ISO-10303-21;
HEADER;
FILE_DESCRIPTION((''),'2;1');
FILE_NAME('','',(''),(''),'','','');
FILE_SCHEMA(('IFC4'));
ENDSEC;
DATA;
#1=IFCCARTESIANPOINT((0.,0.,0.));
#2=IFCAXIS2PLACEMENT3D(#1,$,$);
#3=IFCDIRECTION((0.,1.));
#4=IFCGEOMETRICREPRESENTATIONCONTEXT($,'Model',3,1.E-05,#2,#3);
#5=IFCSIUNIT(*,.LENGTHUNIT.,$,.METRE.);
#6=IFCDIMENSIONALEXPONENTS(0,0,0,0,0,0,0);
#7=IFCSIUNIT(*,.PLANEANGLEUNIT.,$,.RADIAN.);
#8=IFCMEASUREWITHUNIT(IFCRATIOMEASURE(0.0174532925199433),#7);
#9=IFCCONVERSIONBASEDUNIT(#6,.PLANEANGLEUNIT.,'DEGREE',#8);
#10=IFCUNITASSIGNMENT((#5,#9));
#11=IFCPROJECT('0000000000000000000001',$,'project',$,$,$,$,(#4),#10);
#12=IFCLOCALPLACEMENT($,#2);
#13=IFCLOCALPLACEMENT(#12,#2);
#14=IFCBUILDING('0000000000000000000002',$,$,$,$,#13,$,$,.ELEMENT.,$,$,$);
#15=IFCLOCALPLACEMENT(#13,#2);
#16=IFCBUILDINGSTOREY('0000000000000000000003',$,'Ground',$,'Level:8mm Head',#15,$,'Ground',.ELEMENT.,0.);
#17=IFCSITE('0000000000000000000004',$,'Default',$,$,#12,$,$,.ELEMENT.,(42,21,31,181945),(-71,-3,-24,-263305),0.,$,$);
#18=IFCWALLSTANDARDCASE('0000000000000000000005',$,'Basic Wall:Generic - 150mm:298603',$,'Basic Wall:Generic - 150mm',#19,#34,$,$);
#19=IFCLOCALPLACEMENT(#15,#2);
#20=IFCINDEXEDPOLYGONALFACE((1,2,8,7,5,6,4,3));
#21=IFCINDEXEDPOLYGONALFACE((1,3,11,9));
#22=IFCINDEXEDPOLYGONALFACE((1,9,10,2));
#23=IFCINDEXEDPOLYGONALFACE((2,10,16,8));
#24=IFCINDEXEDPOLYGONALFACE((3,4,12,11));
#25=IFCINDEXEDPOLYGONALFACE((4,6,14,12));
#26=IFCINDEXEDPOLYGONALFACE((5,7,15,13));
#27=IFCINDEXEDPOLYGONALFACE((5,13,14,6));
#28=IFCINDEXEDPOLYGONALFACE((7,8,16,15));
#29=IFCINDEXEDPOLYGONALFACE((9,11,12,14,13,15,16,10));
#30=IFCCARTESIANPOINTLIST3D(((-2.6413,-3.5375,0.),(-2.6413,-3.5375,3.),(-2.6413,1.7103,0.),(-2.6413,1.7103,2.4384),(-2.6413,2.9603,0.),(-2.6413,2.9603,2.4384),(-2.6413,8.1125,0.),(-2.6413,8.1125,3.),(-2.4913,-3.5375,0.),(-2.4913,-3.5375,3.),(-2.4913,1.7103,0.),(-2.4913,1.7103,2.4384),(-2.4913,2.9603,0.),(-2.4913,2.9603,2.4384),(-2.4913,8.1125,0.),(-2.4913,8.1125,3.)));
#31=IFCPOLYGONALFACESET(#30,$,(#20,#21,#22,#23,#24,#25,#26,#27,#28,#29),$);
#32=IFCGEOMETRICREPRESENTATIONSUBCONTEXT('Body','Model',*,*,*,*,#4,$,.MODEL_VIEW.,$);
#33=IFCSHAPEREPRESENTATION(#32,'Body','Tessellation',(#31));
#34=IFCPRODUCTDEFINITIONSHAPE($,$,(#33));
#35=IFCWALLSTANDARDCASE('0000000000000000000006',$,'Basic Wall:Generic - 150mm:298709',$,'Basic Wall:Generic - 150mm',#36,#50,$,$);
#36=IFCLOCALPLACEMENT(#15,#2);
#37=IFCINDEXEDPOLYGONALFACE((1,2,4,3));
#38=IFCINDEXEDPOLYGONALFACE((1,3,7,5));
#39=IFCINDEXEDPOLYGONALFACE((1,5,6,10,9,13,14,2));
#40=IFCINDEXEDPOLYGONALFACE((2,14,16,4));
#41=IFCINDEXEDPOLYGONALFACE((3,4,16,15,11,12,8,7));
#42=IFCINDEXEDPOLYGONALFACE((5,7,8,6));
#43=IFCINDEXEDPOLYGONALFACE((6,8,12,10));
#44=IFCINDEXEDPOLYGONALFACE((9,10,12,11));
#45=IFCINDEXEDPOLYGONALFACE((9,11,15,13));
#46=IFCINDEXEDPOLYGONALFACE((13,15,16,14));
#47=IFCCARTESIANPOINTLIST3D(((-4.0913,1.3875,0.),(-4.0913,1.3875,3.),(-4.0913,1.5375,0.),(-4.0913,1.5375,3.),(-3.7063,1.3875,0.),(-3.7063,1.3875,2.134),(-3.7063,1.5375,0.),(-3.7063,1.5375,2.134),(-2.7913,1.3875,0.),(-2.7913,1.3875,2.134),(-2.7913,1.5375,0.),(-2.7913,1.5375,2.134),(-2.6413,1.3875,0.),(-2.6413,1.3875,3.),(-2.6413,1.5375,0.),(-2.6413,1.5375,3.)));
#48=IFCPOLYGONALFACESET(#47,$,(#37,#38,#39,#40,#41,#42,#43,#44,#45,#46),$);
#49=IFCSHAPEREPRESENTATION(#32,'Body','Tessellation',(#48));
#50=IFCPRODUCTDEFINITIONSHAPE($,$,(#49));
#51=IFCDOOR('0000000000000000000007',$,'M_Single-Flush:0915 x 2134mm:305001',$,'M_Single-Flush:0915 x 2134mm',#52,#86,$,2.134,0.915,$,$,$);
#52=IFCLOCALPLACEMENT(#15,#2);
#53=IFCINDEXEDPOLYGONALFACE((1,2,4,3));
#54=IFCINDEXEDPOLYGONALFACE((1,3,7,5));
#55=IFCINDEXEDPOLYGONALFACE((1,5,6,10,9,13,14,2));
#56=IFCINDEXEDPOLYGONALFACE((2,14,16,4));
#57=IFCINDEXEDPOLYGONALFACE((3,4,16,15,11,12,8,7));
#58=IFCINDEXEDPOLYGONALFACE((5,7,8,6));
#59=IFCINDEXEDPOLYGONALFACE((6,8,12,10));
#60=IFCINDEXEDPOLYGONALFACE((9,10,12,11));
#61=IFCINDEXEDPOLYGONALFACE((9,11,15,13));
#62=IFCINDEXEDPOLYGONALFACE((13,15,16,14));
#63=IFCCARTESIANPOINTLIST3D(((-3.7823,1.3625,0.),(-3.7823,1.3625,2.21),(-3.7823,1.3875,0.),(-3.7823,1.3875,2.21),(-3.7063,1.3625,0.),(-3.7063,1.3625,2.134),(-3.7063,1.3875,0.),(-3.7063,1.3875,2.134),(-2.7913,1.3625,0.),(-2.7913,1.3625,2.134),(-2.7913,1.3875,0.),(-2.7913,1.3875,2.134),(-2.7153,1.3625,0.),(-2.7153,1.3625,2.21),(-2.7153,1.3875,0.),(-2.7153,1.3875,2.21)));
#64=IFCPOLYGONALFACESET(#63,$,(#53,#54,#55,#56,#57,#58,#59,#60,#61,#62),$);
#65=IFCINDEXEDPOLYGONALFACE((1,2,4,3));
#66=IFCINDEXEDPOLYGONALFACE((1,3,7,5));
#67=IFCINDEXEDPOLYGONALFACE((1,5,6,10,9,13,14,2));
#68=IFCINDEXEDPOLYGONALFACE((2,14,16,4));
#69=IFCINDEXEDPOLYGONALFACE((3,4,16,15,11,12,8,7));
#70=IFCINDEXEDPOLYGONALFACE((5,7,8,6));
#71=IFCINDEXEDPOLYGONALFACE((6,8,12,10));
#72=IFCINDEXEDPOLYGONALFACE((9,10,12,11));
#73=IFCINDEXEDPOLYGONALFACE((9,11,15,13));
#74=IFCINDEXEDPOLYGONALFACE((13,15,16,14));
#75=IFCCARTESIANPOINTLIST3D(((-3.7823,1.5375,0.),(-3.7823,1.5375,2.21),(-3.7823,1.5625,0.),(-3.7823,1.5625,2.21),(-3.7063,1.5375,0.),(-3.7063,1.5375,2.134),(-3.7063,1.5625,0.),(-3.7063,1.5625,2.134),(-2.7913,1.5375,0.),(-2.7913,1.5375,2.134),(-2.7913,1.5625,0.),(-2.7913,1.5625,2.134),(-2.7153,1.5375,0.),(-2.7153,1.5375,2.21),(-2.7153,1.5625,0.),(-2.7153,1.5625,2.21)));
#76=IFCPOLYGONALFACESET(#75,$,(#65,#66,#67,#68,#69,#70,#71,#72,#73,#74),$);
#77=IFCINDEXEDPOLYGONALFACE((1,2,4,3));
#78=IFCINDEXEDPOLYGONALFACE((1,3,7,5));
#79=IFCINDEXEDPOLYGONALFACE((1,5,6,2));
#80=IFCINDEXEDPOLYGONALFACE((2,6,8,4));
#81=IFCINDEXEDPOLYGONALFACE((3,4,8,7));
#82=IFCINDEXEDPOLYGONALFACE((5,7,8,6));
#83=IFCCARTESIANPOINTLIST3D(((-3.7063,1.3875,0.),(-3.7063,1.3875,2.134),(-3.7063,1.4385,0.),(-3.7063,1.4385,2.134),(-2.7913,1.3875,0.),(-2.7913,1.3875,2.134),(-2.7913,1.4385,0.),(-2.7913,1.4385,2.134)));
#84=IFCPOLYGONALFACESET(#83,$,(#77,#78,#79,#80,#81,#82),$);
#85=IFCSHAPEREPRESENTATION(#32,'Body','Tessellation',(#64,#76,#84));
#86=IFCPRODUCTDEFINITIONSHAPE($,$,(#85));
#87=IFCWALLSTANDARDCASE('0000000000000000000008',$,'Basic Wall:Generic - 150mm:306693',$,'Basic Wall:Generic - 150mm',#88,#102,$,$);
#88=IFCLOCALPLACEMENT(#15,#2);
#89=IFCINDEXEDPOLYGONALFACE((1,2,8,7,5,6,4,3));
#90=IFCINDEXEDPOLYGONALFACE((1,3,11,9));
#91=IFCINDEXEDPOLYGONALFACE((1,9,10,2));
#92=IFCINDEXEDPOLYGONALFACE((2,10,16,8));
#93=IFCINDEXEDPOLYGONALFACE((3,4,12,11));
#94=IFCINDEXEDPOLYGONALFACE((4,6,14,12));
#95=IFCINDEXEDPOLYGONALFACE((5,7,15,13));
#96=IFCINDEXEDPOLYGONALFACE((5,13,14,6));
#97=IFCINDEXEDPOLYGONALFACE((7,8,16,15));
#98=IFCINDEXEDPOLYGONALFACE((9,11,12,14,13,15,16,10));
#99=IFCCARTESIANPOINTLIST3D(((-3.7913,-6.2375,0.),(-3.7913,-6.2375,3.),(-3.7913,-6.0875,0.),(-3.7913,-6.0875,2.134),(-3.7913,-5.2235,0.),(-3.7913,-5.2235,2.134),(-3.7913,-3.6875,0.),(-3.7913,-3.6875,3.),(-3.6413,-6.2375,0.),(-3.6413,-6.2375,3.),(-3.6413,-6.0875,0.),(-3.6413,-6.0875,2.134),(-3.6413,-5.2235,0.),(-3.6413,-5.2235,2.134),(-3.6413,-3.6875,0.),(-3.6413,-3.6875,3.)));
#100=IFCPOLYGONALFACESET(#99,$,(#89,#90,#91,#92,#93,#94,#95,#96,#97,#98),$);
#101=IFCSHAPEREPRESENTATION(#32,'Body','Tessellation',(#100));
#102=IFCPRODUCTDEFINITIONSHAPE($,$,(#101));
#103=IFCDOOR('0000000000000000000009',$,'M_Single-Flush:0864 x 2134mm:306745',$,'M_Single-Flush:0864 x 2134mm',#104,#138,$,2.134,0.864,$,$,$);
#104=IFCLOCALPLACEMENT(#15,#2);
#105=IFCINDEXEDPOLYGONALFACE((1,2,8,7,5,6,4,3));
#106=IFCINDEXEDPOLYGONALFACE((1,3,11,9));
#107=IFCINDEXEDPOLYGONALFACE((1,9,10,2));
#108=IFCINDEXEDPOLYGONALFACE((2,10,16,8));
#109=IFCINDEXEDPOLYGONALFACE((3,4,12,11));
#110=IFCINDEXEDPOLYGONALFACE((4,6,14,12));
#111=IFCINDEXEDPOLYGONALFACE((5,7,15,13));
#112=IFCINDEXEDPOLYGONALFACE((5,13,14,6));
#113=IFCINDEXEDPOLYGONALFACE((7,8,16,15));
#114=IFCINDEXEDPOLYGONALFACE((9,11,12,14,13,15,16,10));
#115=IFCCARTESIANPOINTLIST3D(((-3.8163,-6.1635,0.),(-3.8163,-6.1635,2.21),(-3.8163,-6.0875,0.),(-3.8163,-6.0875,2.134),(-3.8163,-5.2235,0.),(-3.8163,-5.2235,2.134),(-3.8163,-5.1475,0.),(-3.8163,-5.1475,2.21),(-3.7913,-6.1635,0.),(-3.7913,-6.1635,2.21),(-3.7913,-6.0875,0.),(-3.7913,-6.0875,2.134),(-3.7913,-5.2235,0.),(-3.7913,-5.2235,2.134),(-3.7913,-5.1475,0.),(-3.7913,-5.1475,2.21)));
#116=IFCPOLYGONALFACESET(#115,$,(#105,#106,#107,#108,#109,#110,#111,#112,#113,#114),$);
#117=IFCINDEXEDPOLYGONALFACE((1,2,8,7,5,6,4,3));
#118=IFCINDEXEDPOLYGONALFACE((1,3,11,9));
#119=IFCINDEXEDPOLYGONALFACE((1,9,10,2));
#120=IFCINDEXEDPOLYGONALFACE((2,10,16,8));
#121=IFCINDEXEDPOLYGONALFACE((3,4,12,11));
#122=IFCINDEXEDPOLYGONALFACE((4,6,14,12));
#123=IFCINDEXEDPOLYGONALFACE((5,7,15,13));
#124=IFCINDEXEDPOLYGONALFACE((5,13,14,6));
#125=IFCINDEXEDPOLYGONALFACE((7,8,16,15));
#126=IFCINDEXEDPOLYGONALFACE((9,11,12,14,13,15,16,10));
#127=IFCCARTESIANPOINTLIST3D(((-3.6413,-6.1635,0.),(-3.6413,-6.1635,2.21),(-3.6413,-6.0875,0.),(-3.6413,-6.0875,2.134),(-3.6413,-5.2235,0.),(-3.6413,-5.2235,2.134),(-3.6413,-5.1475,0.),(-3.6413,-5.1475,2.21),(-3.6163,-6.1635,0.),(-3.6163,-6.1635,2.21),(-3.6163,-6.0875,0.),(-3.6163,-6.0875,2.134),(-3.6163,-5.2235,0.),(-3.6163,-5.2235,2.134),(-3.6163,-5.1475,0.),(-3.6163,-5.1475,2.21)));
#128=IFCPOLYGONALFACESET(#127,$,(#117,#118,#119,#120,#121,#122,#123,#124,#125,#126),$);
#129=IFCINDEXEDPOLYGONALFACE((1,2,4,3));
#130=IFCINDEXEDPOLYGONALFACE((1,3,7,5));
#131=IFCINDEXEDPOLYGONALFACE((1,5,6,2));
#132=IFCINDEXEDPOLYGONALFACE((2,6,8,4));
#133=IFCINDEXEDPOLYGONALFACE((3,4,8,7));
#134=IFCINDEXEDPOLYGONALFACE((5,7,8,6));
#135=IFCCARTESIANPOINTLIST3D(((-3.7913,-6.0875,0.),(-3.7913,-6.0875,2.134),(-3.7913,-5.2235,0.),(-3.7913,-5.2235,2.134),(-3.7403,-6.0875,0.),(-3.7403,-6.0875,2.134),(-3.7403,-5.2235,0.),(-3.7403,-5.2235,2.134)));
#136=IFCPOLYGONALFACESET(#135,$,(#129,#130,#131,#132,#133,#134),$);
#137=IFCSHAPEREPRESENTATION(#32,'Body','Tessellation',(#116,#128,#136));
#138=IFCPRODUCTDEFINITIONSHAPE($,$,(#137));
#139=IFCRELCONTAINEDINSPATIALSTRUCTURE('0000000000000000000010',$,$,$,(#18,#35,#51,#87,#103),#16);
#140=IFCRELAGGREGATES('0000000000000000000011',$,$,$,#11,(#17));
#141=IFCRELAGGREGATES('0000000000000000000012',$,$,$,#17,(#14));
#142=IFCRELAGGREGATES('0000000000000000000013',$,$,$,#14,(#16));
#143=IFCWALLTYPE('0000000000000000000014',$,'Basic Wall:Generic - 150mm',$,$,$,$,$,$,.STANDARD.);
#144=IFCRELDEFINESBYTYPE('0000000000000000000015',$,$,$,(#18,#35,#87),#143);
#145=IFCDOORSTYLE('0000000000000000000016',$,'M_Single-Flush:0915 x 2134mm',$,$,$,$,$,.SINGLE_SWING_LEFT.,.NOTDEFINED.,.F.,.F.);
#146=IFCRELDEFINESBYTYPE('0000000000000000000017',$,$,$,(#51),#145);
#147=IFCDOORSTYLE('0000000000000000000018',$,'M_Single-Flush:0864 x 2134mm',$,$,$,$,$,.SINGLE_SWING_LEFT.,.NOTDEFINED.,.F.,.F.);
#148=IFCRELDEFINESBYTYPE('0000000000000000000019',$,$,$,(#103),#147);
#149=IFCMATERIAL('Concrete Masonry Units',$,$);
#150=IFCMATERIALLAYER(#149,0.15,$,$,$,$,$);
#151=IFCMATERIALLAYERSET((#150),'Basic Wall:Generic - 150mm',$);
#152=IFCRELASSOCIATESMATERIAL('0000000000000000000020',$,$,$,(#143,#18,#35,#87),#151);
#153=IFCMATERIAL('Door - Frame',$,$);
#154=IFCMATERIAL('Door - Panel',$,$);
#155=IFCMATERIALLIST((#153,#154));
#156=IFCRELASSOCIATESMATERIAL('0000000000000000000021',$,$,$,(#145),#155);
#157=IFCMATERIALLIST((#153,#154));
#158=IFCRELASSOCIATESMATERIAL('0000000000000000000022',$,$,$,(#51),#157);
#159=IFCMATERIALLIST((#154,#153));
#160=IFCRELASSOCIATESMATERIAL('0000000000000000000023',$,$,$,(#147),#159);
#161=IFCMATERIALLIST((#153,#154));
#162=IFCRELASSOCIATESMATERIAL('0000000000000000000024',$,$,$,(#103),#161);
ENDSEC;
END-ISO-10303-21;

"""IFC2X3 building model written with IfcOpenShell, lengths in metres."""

from ifc_helpers import new_model, entity, si_unit, converted_unit, direction, frame, frame_2d, origin, origin_2d_with_axis, place, context, subcontext, project, spatial, polyline, rectangle, outline, extrude, source, transform, mapped, material, material_list, layer, layer_set, layer_usage, type_object, type_shapes, element, fill, save


model = new_model("IFC2X3")

# Units and contexts
model_context = context("Model", 3, precision=1e-05, world=origin(), true_north=direction((0.0, 1.0)))
body_context = subcontext(model_context, "Body", "Model", "MODEL_VIEW")
ifc_project = project(units=[si_unit("LENGTHUNIT", "METRE"), converted_unit("PLANEANGLEUNIT", "DEGREE", entity("IfcRatioMeasure", 0.0174532925199433), si_unit("PLANEANGLEUNIT", "RADIAN"), dimensions=[0, 0, 0, 0, 0, 0, 0])], contexts=[model_context])

# Site, building, storey
site_placement = place(None, origin())
site = spatial("IfcSite", under=ifc_project, at=site_placement, Name="Default", CompositionType="ELEMENT", RefLatitude=(42, 21, 31, 181945), RefLongitude=(-71, -3, -24, -263305), RefElevation=0.0)
building_placement = place(site_placement, origin())
building = spatial("IfcBuilding", under=site, at=building_placement, CompositionType="ELEMENT")
storey_placement = place(building_placement, origin())
storey = spatial("IfcBuildingStorey", under=building, at=storey_placement, Name="Ground", ObjectType="Level:8mm Head", LongName="Ground", CompositionType="ELEMENT", Elevation=0.0)

# Shared definitions
ifc_material_1 = material(Name="Concrete Masonry Units")
ifc_layer = layer(ifc_material_1, 0.15)
ifc_layer_set = layer_set([ifc_layer], Name="Basic Wall:Generic - 150mm")
wall_type = type_object("IfcWallType", Name="Basic Wall:Generic - 150mm", PredefinedType="STANDARD", material=ifc_layer_set)
ifc_material_2 = material(Name="Door - Frame")
ifc_material_3 = material(Name="Door - Panel")
ifc_material_list_1 = material_list([ifc_material_2, ifc_material_3])
door_style_1 = type_object("IfcDoorStyle", Name="M_Single-Flush:0915 x 2134mm", ConstructionType="NOTDEFINED", OperationType="SINGLE_SWING_LEFT", ParameterTakesPrecedence=False, Sizeable=False, material=ifc_material_list_1)
shared_shape_1 = source(origin(), body_context, "Body", "SweptSolid", [
    extrude(outline(polyline([(-0.5335, -1.124), (0.5335, -1.124), (0.5335, 1.086), (0.4575, 1.086), (0.4575, -1.048), (-0.4575, -1.048), (-0.4575, 1.086), (-0.5335, 1.086), (-0.5335, -1.124)])), frame((0.4575, 0.175, 1.086), z_axis=(0.0, -1.0, 0.0), x_axis=(-1.0, 0.0, 0.0)), (0.0, 0.0, 1.0), 0.025),
    extrude(outline(polyline([(-1.124, -0.5335), (1.086, -0.5335), (1.086, -0.4575), (-1.048, -0.4575), (-1.048, 0.4575), (1.086, 0.4575), (1.086, 0.5335), (-1.124, 0.5335), (-1.124, -0.5335)])), frame((0.4575, 0.0, 1.086), z_axis=(0.0, -1.0, 0.0), x_axis=(0.0, 0.0, -1.0)), (0.0, 0.0, 1.0), 0.025),
    extrude(rectangle(XDim=0.915, YDim=0.051, at=frame_2d((0.0, 0.0), x_axis=(1.0, 0.0))), frame((0.4575, 0.1245, 0.0)), (0.0, 0.0, 1.0), 2.134),
])
type_shapes(door_style_1, [shared_shape_1])

# Wall, opening
ifc_layer_usage_1 = layer_usage(ifc_layer_set, "AXIS2", "POSITIVE", -0.075)
wall_1_placement = place(storey_placement, frame((-2.5663, -3.5375, 0.0), z_axis=(0.0, 0.0, 1.0), x_axis=(0.0, 1.0, 0.0)))
wall_1 = element("IfcWallStandardCase", 1, at=wall_1_placement, inside=storey, type_object=wall_type, material=ifc_layer_usage_1, Name="Basic Wall:Generic - 150mm:298603", ObjectType="Basic Wall:Generic - 150mm", context=body_context, shape_type="SweptSolid", body=[
    extrude(rectangle(XDim=11.65, YDim=0.15, at=frame_2d((5.825, 0.0), x_axis=(-1.0, 0.0))), origin(), (0.0, 0.0, 1.0), 3.0),
])
opening_1_placement = place(wall_1_placement, origin())
element("IfcOpeningElement", 2, at=opening_1_placement, cuts=wall_1, ObjectType="Opening", context=body_context, shape_type="SweptSolid", body=[
    extrude(rectangle(XDim=2.4384, YDim=1.25, at=origin_2d_with_axis()), frame((5.8728, -0.075, 1.2192), z_axis=(0.0, 1.0, 0.0), x_axis=(0.0, 0.0, -1.0)), (0.0, 0.0, 1.0), 0.15),
])

# Walls, openings, doors
ifc_layer_usage_2 = layer_usage(ifc_layer_set, "AXIS2", "NEGATIVE", 0.075)
wall_2_placement = place(storey_placement, frame((-4.0913, 1.4625, 0.0)))
wall_2 = element("IfcWallStandardCase", 3, at=wall_2_placement, inside=storey, type_object=wall_type, material=ifc_layer_usage_2, Name="Basic Wall:Generic - 150mm:298709", ObjectType="Basic Wall:Generic - 150mm", context=body_context, shape_type="SweptSolid", body=[
    extrude(rectangle(XDim=1.45, YDim=0.15, at=frame_2d((0.725, 0.0), x_axis=(-1.0, 0.0))), origin(), (0.0, 0.0, 1.0), 3.0),
])
opening_2_placement = place(wall_2_placement, frame((1.3, 0.075, 0.0)))
opening_2 = element("IfcOpeningElement", 4, at=opening_2_placement, cuts=wall_2, ObjectType="Opening", context=body_context, shape_type="SweptSolid", body=[
    extrude(rectangle(XDim=0.915, YDim=2.134, at=frame_2d((1.067, 0.4575), x_axis=(0.0, -1.0))), frame((0.0, 0.0, 0.0), z_axis=(0.0, -1.0, 0.0), x_axis=(0.0, 0.0, 1.0)), (0.0, 0.0, 1.0), 0.15),
])
ifc_material_list_2 = material_list([ifc_material_2, ifc_material_3])
door_1_placement = place(opening_2_placement, frame((0.0, 0.0, 0.0), z_axis=(0.0, 0.0, 1.0), x_axis=(-1.0, 0.0, 0.0)))
door_1 = element("IfcDoor", 5, at=door_1_placement, inside=storey, type_object=door_style_1, material=ifc_material_list_2, Name="M_Single-Flush:0915 x 2134mm:305001", ObjectType="M_Single-Flush:0915 x 2134mm", OverallHeight=2.134, OverallWidth=0.915, context=body_context, shape_type="MappedRepresentation", body=[
    mapped(shared_shape_1, transform((0.0, 0.0, 0.0), scale=1.0)),
])
fill(opening_2, door_1)
ifc_layer_usage_3 = layer_usage(ifc_layer_set, "AXIS2", "NEGATIVE", 0.075)
wall_3_placement = place(storey_placement, frame((-3.7163, -6.2375, 0.0), z_axis=(0.0, 0.0, 1.0), x_axis=(0.0, 1.0, 0.0)))
wall_3 = element("IfcWallStandardCase", 6, at=wall_3_placement, inside=storey, type_object=wall_type, material=ifc_layer_usage_3, Name="Basic Wall:Generic - 150mm:306693", ObjectType="Basic Wall:Generic - 150mm", context=body_context, shape_type="SweptSolid", body=[
    extrude(rectangle(XDim=2.55, YDim=0.15, at=frame_2d((1.275, 0.0), x_axis=(-1.0, 0.0))), origin(), (0.0, 0.0, 1.0), 3.0),
])
opening_3_placement = place(wall_3_placement, frame((0.15, -0.075, 0.0)))
opening_3 = element("IfcOpeningElement", 7, at=opening_3_placement, cuts=wall_3, ObjectType="Opening", context=body_context, shape_type="SweptSolid", body=[
    extrude(rectangle(XDim=0.864, YDim=2.134, at=frame_2d((1.067, 0.432), x_axis=(0.0, -1.0))), frame((0.0, 0.0, 0.0), z_axis=(0.0, 1.0, 0.0), x_axis=(0.0, 0.0, 1.0)), (0.0, 0.0, 1.0), 0.15),
])
ifc_material_list_3 = material_list([ifc_material_2, ifc_material_3])
ifc_material_list_4 = material_list([ifc_material_3, ifc_material_2])
door_style_2 = type_object("IfcDoorStyle", Name="M_Single-Flush:0864 x 2134mm", ConstructionType="NOTDEFINED", OperationType="SINGLE_SWING_LEFT", ParameterTakesPrecedence=False, Sizeable=False, material=ifc_material_list_4)
shared_shape_2 = source(origin(), body_context, "Body", "SweptSolid", [
    extrude(outline(polyline([(-0.508, -1.124), (0.508, -1.124), (0.508, 1.086), (0.432, 1.086), (0.432, -1.048), (-0.432, -1.048), (-0.432, 1.086), (-0.508, 1.086), (-0.508, -1.124)])), frame((0.432, 0.175, 1.086), z_axis=(0.0, -1.0, 0.0), x_axis=(-1.0, 0.0, 0.0)), (0.0, 0.0, 1.0), 0.025),
    extrude(outline(polyline([(-1.124, -0.508), (1.086, -0.508), (1.086, -0.432), (-1.048, -0.432), (-1.048, 0.432), (1.086, 0.432), (1.086, 0.508), (-1.124, 0.508), (-1.124, -0.508)])), frame((0.432, 0.0, 1.086), z_axis=(0.0, -1.0, 0.0), x_axis=(0.0, 0.0, -1.0)), (0.0, 0.0, 1.0), 0.025),
    extrude(rectangle(XDim=0.864, YDim=0.051, at=frame_2d((0.0, 0.0), x_axis=(1.0, 0.0))), frame((0.432, 0.1245, 0.0)), (0.0, 0.0, 1.0), 2.134),
])
type_shapes(door_style_2, [shared_shape_2])
door_2_placement = place(opening_3_placement, origin())
door_2 = element("IfcDoor", 8, at=door_2_placement, inside=storey, type_object=door_style_2, material=ifc_material_list_3, Name="M_Single-Flush:0864 x 2134mm:306745", ObjectType="M_Single-Flush:0864 x 2134mm", OverallHeight=2.134, OverallWidth=0.864, context=body_context, shape_type="MappedRepresentation", body=[
    mapped(shared_shape_2, transform((0.0, 0.0, 0.0), scale=1.0)),
])
fill(opening_3, door_2)

save(model, "model.ifc")
